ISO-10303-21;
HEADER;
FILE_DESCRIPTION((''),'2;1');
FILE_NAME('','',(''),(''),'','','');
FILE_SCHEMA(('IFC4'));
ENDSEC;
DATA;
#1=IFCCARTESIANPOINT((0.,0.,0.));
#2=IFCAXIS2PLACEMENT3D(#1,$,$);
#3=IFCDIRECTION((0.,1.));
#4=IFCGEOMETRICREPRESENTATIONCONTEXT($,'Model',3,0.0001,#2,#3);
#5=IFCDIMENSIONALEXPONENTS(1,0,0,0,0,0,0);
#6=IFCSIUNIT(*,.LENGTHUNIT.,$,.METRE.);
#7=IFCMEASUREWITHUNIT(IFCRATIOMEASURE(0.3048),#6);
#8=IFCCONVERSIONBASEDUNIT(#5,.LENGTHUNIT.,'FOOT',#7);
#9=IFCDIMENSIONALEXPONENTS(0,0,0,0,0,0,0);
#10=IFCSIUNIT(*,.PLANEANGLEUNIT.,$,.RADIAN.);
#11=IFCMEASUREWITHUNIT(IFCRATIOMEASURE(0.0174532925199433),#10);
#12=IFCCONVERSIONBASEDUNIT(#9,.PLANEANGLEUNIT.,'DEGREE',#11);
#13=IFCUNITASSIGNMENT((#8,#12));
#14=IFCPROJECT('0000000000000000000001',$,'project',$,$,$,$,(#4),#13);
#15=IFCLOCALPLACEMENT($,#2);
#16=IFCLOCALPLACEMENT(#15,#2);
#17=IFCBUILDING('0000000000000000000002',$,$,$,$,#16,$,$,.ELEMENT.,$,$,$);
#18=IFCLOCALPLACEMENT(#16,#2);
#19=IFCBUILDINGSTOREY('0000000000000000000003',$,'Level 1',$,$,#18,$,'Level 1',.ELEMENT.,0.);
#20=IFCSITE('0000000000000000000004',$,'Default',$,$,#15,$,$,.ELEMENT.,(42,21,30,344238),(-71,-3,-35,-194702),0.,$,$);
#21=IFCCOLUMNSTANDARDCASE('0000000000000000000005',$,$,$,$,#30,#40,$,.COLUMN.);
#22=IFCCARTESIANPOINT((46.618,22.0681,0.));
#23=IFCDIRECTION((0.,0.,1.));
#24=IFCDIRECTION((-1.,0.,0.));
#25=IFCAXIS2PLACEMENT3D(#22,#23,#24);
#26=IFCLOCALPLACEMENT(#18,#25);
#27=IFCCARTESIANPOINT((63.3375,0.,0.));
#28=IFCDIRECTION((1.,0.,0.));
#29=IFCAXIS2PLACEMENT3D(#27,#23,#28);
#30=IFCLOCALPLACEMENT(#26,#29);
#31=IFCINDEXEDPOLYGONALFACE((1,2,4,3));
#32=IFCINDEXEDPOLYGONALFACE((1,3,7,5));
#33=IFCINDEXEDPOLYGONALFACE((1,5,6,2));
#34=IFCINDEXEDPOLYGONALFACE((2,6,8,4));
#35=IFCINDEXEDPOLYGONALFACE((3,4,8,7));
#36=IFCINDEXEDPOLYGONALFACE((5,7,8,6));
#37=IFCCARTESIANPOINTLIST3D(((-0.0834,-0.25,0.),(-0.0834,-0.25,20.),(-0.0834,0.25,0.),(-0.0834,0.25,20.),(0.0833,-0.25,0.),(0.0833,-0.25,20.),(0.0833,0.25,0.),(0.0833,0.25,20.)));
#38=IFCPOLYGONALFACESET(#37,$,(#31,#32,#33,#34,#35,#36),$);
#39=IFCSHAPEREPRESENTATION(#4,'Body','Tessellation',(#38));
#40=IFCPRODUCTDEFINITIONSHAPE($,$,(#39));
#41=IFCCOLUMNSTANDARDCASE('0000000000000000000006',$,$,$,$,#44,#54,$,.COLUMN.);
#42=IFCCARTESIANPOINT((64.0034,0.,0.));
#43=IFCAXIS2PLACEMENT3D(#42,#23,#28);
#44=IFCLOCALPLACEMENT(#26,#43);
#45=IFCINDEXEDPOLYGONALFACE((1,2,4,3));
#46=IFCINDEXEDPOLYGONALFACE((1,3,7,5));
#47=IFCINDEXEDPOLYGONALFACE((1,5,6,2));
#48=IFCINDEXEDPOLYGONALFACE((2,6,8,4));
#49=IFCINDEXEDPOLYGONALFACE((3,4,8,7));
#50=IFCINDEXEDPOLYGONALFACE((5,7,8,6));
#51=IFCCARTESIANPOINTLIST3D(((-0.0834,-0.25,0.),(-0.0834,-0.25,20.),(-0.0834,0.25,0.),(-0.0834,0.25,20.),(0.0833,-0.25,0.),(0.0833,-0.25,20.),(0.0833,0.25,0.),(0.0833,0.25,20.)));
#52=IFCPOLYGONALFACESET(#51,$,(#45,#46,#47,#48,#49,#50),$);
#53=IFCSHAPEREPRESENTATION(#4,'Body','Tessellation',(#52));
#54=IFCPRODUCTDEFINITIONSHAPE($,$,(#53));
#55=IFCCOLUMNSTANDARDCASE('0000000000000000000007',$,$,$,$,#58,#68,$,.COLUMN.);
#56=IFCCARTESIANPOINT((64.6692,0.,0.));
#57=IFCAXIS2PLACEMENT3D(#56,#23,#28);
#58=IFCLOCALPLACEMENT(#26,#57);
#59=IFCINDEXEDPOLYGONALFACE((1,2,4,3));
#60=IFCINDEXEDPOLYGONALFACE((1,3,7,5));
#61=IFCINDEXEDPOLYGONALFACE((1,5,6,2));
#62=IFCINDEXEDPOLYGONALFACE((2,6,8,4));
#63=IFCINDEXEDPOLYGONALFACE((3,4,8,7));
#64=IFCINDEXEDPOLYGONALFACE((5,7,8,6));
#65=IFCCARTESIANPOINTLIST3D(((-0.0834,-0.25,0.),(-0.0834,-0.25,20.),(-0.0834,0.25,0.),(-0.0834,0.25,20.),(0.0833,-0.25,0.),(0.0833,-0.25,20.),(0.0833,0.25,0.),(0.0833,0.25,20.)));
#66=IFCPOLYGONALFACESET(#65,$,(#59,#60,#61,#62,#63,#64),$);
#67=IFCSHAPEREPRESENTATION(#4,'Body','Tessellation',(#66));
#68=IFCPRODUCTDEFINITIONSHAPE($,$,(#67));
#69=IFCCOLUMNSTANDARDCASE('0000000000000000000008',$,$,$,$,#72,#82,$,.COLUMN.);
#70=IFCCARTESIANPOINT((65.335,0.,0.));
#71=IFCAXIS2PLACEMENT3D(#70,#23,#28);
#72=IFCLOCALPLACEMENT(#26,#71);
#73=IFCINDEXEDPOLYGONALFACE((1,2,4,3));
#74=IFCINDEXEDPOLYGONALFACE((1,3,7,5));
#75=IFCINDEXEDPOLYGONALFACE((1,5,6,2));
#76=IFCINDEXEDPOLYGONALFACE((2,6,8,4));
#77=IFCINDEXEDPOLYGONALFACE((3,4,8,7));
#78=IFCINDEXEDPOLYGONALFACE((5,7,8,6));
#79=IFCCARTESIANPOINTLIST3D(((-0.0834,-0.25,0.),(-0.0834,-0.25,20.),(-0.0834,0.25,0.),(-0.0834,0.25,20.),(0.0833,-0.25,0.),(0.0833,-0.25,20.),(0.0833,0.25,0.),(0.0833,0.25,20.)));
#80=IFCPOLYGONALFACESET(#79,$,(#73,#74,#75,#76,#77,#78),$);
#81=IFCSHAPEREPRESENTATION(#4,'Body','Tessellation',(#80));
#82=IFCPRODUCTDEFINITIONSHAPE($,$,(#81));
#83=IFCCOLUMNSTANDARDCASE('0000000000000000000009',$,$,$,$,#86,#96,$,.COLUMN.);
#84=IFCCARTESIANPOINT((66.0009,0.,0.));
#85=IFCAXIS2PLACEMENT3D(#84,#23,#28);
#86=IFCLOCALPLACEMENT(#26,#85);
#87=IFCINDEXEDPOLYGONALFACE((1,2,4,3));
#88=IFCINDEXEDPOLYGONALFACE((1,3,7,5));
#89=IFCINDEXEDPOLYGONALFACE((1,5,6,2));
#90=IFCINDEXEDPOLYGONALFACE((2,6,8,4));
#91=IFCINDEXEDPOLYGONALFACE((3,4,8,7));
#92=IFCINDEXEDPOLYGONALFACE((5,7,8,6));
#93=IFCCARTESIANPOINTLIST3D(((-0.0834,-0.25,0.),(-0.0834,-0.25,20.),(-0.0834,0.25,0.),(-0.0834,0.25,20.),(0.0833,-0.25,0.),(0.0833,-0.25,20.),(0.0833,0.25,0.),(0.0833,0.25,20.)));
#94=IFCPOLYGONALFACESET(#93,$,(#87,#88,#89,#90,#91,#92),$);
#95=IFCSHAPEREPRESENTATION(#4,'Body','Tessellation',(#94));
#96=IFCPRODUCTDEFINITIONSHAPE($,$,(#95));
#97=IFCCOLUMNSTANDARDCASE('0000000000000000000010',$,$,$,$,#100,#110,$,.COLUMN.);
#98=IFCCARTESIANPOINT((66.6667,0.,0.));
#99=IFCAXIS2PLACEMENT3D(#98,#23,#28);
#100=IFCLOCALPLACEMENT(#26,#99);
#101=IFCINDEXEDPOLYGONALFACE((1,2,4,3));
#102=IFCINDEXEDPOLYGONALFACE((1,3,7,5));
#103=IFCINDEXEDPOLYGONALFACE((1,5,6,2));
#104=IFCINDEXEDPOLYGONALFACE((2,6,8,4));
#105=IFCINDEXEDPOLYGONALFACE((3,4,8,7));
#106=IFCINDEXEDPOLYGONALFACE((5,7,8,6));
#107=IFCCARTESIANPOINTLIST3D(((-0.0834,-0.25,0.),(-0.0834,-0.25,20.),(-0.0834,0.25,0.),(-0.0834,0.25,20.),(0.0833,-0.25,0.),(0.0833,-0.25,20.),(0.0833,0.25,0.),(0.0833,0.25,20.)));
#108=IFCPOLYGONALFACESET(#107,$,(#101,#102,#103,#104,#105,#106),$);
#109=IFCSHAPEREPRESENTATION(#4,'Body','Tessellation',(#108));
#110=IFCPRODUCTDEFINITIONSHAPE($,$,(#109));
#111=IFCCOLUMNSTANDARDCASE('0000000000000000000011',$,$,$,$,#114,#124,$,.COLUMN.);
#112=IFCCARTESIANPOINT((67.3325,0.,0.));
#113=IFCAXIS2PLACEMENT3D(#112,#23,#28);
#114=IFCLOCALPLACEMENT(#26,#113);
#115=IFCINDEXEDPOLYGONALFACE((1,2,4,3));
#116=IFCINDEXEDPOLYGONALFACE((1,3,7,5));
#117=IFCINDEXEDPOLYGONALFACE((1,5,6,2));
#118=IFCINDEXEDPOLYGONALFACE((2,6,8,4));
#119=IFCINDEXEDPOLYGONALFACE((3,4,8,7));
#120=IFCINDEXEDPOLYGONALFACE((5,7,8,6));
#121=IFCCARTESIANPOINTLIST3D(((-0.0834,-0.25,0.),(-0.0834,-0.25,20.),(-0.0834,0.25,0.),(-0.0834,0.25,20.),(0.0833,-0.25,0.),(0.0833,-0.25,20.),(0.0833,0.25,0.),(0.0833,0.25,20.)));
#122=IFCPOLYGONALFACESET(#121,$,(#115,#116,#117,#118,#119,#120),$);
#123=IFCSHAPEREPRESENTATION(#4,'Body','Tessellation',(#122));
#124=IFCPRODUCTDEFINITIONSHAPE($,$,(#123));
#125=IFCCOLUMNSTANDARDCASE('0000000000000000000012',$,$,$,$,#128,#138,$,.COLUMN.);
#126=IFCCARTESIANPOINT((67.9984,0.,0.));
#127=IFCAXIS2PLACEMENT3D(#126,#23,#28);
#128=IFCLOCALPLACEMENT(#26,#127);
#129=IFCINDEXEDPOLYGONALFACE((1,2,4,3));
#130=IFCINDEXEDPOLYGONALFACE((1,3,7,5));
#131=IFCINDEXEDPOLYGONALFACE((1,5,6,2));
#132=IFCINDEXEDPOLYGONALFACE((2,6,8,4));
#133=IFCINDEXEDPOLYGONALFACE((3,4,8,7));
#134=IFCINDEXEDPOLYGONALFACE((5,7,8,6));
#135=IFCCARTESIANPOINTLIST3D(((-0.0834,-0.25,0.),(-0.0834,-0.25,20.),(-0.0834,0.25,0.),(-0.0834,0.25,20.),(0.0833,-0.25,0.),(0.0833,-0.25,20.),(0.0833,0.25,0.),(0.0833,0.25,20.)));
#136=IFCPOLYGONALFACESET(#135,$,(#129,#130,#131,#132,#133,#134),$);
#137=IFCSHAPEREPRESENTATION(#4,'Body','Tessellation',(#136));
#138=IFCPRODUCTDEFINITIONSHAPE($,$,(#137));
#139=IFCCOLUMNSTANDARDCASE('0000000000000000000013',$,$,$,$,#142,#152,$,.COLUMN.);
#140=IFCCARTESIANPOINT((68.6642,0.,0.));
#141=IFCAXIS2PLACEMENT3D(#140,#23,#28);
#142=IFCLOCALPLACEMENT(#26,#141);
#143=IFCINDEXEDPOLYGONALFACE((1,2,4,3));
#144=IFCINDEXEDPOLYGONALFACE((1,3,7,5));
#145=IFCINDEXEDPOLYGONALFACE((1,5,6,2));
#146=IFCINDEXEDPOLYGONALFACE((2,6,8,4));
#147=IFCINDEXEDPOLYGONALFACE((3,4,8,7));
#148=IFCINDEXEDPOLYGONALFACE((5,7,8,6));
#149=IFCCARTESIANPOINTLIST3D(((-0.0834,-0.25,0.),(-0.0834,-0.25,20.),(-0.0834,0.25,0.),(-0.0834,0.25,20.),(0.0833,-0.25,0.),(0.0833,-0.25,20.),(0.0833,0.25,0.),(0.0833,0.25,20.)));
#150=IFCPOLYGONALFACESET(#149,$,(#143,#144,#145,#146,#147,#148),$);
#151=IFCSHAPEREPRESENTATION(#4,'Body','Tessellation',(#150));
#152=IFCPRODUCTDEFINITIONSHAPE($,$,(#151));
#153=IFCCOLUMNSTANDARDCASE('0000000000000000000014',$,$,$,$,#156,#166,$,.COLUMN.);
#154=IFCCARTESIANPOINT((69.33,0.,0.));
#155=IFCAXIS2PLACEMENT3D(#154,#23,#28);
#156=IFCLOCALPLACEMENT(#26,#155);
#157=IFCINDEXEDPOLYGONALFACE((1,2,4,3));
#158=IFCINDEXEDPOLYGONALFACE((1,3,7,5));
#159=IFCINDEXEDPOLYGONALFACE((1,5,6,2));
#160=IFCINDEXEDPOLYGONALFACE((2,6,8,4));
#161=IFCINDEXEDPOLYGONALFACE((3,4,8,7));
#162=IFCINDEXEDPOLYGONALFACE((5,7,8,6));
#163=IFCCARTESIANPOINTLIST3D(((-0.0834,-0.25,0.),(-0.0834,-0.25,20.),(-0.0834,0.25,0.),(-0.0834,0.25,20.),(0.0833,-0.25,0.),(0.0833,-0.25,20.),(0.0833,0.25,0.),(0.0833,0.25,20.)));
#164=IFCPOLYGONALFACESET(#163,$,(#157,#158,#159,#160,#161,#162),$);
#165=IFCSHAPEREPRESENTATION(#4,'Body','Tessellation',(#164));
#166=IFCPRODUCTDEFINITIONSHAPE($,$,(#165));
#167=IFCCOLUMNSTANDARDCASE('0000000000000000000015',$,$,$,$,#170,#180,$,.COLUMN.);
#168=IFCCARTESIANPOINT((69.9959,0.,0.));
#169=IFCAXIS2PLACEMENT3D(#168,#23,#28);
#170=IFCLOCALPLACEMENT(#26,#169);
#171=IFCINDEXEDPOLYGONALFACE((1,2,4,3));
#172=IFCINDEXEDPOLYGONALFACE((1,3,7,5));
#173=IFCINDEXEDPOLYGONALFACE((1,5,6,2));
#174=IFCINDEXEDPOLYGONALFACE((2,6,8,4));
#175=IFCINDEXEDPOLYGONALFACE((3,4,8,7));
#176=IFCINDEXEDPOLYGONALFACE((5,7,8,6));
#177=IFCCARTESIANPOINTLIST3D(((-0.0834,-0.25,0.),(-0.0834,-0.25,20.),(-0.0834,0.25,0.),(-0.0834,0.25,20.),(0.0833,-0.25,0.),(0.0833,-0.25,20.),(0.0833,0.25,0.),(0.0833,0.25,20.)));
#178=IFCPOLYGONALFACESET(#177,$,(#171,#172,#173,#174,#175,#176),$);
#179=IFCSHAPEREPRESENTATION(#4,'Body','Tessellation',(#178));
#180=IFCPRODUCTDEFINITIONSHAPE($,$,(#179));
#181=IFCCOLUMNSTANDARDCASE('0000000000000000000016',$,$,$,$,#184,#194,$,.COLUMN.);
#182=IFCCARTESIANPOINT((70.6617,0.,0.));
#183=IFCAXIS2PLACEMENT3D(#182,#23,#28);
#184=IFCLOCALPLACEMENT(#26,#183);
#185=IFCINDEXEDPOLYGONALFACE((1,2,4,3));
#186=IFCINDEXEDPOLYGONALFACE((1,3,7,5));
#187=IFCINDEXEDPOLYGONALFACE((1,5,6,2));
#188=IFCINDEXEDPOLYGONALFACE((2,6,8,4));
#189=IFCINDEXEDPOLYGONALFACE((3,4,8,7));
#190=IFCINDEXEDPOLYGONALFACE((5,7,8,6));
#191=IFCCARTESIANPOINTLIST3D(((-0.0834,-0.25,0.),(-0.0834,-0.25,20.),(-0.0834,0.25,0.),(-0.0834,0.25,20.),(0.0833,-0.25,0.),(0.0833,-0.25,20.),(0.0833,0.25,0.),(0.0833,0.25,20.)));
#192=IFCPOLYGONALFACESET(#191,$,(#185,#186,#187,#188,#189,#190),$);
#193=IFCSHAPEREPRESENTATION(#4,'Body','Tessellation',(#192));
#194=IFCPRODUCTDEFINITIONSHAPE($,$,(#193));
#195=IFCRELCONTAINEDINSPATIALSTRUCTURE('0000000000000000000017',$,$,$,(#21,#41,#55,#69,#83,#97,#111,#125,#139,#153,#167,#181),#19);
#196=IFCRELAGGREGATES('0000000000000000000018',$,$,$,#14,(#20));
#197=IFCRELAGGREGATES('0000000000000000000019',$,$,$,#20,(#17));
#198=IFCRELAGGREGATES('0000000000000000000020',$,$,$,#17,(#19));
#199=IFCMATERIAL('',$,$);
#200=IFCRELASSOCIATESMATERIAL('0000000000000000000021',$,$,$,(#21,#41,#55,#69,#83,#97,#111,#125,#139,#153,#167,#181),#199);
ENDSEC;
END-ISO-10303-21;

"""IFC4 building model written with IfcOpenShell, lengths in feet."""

from ifc_helpers import new_model, entity, si_unit, converted_unit, direction, frame, origin, place, context, project, spatial, rectangle, extrude, material, element, save


model = new_model("IFC4")

# Units and contexts
model_context = context("Model", 3, precision=0.0001, world=origin(), true_north=direction((0.0, 1.0)))
ifc_project = project(units=[converted_unit("LENGTHUNIT", "FOOT", entity("IfcRatioMeasure", 0.3048), si_unit("LENGTHUNIT", "METRE"), dimensions=[1, 0, 0, 0, 0, 0, 0]), converted_unit("PLANEANGLEUNIT", "DEGREE", entity("IfcRatioMeasure", 0.0174532925199433), si_unit("PLANEANGLEUNIT", "RADIAN"), dimensions=[0, 0, 0, 0, 0, 0, 0])], contexts=[model_context])

# Site, building, storey
site_placement = place(None, origin())
site = spatial("IfcSite", under=ifc_project, at=site_placement, Name="Default", CompositionType="ELEMENT", RefLatitude=(42, 21, 30, 344238), RefLongitude=(-71, -3, -35, -194702), RefElevation=0.0)
building_placement = place(site_placement, origin())
building = spatial("IfcBuilding", under=site, at=building_placement, CompositionType="ELEMENT")
storey_placement = place(building_placement, origin())
storey = spatial("IfcBuildingStorey", under=building, at=storey_placement, Name="Level 1", LongName="Level 1", CompositionType="ELEMENT", Elevation=0.0)

# Columns
ifc_material_1 = material(Name="")
placement = place(storey_placement, frame((46.618, 22.0681, 0.0), z_axis=(0.0, 0.0, 1.0), x_axis=(-1.0, 0.0, 0.0)))
for number, where, z_axis, x_axis in (
    (1, (63.3375, 0.0, 0.0), (0.0, 0.0, 1.0), (1.0, 0.0, 0.0)),
    (2, (64.0034, 0.0, 0.0), (0.0, 0.0, 1.0), (1.0, 0.0, 0.0)),
    (3, (64.6692, 0.0, 0.0), (0.0, 0.0, 1.0), (1.0, 0.0, 0.0)),
    (4, (65.335, 0.0, 0.0), (0.0, 0.0, 1.0), (1.0, 0.0, 0.0)),
    (5, (66.0009, 0.0, 0.0), (0.0, 0.0, 1.0), (1.0, 0.0, 0.0)),
    (6, (66.6667, 0.0, 0.0), (0.0, 0.0, 1.0), (1.0, 0.0, 0.0)),
    (7, (67.3325, 0.0, 0.0), (0.0, 0.0, 1.0), (1.0, 0.0, 0.0)),
    (8, (67.9984, 0.0, 0.0), (0.0, 0.0, 1.0), (1.0, 0.0, 0.0)),
    (9, (68.6642, 0.0, 0.0), (0.0, 0.0, 1.0), (1.0, 0.0, 0.0)),
    (10, (69.33, 0.0, 0.0), (0.0, 0.0, 1.0), (1.0, 0.0, 0.0)),
    (11, (69.9959, 0.0, 0.0), (0.0, 0.0, 1.0), (1.0, 0.0, 0.0)),
    (12, (70.6617, 0.0, 0.0), (0.0, 0.0, 1.0), (1.0, 0.0, 0.0)),
):
    element("IfcColumnStandardCase", number, at=place(placement, frame(where, z_axis=z_axis, x_axis=x_axis)), inside=storey, material=ifc_material_1, PredefinedType="COLUMN", context=model_context, shape_type="SweptSolid", body=[
        extrude(rectangle(XDim=0.1667, YDim=0.5), origin(), (0.0, 0.0, 1.0), 20.0),
    ])

save(model, "model.ifc")
